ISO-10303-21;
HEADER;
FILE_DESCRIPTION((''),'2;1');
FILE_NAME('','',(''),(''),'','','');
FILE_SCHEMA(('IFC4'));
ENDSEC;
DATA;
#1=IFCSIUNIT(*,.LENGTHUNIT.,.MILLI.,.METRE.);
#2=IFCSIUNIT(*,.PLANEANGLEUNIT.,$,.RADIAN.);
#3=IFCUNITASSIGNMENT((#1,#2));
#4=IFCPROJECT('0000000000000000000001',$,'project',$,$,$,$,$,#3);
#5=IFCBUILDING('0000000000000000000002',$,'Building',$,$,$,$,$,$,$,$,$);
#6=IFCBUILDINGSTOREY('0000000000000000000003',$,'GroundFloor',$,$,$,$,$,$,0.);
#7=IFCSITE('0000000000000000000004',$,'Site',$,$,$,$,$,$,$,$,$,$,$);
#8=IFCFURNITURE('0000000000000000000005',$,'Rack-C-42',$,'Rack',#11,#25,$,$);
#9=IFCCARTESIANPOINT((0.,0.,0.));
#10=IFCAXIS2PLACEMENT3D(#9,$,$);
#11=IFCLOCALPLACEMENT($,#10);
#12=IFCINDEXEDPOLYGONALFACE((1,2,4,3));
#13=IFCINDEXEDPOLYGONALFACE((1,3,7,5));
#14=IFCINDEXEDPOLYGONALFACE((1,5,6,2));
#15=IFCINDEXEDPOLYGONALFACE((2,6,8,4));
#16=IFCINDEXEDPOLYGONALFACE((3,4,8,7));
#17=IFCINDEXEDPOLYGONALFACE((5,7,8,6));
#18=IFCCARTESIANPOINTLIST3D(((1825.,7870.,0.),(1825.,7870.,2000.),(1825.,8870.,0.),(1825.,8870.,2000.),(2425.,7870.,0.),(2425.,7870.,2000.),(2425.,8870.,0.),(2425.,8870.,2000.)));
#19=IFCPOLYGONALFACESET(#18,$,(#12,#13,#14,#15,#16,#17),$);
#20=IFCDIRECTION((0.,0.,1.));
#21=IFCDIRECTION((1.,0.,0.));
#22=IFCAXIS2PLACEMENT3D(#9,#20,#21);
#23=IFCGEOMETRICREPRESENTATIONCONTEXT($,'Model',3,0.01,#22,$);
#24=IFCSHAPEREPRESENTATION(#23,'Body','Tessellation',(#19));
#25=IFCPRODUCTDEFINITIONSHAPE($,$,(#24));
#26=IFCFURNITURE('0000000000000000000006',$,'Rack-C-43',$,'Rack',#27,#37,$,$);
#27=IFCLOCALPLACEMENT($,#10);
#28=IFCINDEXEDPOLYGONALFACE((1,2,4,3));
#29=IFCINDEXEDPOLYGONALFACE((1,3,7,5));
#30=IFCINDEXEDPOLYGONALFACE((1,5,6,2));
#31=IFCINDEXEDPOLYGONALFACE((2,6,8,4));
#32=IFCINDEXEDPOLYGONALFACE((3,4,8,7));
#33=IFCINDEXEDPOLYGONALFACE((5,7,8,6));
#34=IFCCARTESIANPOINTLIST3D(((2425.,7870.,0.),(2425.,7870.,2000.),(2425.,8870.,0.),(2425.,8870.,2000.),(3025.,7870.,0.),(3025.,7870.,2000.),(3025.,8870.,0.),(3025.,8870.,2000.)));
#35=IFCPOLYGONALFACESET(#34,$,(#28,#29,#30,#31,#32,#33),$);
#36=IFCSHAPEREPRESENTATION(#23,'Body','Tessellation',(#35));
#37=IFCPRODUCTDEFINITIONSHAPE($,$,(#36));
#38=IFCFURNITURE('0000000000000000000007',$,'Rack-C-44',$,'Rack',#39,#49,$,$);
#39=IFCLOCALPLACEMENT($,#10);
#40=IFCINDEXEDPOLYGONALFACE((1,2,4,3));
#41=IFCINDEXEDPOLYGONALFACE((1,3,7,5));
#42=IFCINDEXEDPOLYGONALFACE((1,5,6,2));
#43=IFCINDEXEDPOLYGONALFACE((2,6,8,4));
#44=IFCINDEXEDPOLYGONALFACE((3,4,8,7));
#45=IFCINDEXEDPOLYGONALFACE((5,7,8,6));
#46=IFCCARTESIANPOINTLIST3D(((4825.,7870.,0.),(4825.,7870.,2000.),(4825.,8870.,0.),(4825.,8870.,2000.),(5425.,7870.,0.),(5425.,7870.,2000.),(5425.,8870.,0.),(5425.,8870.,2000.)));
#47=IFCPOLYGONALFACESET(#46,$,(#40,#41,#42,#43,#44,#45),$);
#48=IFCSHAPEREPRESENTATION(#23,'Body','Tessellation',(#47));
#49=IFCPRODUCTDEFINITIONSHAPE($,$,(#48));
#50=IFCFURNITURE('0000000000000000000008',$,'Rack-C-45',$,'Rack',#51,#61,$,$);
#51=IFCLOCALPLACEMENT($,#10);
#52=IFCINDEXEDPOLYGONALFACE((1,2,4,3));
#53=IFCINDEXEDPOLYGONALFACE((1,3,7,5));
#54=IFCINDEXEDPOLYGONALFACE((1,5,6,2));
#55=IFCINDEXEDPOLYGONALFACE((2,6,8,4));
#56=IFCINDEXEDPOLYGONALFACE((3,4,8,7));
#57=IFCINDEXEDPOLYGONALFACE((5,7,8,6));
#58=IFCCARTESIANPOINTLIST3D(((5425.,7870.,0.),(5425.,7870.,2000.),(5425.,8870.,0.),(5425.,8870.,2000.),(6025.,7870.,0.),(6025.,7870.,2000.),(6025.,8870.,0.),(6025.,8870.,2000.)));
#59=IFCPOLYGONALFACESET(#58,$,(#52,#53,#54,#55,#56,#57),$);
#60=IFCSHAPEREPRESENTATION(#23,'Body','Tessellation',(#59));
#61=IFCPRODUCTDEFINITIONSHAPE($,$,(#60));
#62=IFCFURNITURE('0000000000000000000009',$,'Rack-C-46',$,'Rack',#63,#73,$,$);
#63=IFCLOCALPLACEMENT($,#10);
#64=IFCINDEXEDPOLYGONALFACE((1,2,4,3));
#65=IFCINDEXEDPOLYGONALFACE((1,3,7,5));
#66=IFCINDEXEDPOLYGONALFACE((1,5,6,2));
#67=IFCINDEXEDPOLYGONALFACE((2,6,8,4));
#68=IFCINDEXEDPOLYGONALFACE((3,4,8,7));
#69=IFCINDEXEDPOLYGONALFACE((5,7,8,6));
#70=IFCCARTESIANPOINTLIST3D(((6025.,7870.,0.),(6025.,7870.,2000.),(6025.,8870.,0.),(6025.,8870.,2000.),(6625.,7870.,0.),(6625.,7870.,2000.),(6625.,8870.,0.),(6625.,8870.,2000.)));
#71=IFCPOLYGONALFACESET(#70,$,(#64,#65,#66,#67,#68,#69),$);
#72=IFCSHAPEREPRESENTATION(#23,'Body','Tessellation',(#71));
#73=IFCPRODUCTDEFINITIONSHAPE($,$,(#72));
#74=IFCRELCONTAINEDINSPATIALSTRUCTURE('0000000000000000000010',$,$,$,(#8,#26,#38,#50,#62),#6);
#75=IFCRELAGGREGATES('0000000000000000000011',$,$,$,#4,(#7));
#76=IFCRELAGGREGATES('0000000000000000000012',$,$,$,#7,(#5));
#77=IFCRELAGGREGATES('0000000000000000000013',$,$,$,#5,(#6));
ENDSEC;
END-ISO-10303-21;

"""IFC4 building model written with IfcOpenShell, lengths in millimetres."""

from ifc_helpers import new_model, si_unit, frame, origin, origin_with_axes, origin_2d, place, context, project, spatial, rectangle, extrude, element, save


model = new_model("IFC4")

# Units and contexts
model_context = context("Model", 3, precision=0.01, world=origin_with_axes())
ifc_project = project(units=[si_unit("LENGTHUNIT", "METRE", prefix="MILLI"), si_unit("PLANEANGLEUNIT", "RADIAN")])

# Site, building, storey
site = spatial("IfcSite", under=ifc_project, Name="Site")
building = spatial("IfcBuilding", under=site, Name="Building")
storey = spatial("IfcBuildingStorey", under=building, Name="GroundFloor", Elevation=0.0)

# Furniture
for number, where, z_axis, x_axis, name in (
    (1, (2125.0, 8370.0, 0.0), (0.0, 0.0, 1.0), (1.0, 0.0, 0.0), "Rack-C-42"),
    (2, (2725.0, 8370.0, 0.0), (0.0, 0.0, 1.0), (1.0, 0.0, 0.0), "Rack-C-43"),
    (3, (5125.0, 8370.0, 0.0), (0.0, 0.0, 1.0), (1.0, 0.0, 0.0), "Rack-C-44"),
    (4, (5725.0, 8370.0, 0.0), (0.0, 0.0, 1.0), (1.0, 0.0, 0.0), "Rack-C-45"),
    (5, (6325.0, 8370.0, 0.0), (0.0, 0.0, 1.0), (1.0, 0.0, 0.0), "Rack-C-46"),
):
    element("IfcFurniture", number, at=place(None, frame(where, z_axis=z_axis, x_axis=x_axis)), inside=storey, Name=name, ObjectType="Rack", context=model_context, shape_type="SweptSolid", body=[
        extrude(rectangle(XDim=600.0, YDim=1000.0, at=origin_2d()), origin(), (0.0, 0.0, 1.0), 2000.0),
    ])

save(model, "model.ifc")
